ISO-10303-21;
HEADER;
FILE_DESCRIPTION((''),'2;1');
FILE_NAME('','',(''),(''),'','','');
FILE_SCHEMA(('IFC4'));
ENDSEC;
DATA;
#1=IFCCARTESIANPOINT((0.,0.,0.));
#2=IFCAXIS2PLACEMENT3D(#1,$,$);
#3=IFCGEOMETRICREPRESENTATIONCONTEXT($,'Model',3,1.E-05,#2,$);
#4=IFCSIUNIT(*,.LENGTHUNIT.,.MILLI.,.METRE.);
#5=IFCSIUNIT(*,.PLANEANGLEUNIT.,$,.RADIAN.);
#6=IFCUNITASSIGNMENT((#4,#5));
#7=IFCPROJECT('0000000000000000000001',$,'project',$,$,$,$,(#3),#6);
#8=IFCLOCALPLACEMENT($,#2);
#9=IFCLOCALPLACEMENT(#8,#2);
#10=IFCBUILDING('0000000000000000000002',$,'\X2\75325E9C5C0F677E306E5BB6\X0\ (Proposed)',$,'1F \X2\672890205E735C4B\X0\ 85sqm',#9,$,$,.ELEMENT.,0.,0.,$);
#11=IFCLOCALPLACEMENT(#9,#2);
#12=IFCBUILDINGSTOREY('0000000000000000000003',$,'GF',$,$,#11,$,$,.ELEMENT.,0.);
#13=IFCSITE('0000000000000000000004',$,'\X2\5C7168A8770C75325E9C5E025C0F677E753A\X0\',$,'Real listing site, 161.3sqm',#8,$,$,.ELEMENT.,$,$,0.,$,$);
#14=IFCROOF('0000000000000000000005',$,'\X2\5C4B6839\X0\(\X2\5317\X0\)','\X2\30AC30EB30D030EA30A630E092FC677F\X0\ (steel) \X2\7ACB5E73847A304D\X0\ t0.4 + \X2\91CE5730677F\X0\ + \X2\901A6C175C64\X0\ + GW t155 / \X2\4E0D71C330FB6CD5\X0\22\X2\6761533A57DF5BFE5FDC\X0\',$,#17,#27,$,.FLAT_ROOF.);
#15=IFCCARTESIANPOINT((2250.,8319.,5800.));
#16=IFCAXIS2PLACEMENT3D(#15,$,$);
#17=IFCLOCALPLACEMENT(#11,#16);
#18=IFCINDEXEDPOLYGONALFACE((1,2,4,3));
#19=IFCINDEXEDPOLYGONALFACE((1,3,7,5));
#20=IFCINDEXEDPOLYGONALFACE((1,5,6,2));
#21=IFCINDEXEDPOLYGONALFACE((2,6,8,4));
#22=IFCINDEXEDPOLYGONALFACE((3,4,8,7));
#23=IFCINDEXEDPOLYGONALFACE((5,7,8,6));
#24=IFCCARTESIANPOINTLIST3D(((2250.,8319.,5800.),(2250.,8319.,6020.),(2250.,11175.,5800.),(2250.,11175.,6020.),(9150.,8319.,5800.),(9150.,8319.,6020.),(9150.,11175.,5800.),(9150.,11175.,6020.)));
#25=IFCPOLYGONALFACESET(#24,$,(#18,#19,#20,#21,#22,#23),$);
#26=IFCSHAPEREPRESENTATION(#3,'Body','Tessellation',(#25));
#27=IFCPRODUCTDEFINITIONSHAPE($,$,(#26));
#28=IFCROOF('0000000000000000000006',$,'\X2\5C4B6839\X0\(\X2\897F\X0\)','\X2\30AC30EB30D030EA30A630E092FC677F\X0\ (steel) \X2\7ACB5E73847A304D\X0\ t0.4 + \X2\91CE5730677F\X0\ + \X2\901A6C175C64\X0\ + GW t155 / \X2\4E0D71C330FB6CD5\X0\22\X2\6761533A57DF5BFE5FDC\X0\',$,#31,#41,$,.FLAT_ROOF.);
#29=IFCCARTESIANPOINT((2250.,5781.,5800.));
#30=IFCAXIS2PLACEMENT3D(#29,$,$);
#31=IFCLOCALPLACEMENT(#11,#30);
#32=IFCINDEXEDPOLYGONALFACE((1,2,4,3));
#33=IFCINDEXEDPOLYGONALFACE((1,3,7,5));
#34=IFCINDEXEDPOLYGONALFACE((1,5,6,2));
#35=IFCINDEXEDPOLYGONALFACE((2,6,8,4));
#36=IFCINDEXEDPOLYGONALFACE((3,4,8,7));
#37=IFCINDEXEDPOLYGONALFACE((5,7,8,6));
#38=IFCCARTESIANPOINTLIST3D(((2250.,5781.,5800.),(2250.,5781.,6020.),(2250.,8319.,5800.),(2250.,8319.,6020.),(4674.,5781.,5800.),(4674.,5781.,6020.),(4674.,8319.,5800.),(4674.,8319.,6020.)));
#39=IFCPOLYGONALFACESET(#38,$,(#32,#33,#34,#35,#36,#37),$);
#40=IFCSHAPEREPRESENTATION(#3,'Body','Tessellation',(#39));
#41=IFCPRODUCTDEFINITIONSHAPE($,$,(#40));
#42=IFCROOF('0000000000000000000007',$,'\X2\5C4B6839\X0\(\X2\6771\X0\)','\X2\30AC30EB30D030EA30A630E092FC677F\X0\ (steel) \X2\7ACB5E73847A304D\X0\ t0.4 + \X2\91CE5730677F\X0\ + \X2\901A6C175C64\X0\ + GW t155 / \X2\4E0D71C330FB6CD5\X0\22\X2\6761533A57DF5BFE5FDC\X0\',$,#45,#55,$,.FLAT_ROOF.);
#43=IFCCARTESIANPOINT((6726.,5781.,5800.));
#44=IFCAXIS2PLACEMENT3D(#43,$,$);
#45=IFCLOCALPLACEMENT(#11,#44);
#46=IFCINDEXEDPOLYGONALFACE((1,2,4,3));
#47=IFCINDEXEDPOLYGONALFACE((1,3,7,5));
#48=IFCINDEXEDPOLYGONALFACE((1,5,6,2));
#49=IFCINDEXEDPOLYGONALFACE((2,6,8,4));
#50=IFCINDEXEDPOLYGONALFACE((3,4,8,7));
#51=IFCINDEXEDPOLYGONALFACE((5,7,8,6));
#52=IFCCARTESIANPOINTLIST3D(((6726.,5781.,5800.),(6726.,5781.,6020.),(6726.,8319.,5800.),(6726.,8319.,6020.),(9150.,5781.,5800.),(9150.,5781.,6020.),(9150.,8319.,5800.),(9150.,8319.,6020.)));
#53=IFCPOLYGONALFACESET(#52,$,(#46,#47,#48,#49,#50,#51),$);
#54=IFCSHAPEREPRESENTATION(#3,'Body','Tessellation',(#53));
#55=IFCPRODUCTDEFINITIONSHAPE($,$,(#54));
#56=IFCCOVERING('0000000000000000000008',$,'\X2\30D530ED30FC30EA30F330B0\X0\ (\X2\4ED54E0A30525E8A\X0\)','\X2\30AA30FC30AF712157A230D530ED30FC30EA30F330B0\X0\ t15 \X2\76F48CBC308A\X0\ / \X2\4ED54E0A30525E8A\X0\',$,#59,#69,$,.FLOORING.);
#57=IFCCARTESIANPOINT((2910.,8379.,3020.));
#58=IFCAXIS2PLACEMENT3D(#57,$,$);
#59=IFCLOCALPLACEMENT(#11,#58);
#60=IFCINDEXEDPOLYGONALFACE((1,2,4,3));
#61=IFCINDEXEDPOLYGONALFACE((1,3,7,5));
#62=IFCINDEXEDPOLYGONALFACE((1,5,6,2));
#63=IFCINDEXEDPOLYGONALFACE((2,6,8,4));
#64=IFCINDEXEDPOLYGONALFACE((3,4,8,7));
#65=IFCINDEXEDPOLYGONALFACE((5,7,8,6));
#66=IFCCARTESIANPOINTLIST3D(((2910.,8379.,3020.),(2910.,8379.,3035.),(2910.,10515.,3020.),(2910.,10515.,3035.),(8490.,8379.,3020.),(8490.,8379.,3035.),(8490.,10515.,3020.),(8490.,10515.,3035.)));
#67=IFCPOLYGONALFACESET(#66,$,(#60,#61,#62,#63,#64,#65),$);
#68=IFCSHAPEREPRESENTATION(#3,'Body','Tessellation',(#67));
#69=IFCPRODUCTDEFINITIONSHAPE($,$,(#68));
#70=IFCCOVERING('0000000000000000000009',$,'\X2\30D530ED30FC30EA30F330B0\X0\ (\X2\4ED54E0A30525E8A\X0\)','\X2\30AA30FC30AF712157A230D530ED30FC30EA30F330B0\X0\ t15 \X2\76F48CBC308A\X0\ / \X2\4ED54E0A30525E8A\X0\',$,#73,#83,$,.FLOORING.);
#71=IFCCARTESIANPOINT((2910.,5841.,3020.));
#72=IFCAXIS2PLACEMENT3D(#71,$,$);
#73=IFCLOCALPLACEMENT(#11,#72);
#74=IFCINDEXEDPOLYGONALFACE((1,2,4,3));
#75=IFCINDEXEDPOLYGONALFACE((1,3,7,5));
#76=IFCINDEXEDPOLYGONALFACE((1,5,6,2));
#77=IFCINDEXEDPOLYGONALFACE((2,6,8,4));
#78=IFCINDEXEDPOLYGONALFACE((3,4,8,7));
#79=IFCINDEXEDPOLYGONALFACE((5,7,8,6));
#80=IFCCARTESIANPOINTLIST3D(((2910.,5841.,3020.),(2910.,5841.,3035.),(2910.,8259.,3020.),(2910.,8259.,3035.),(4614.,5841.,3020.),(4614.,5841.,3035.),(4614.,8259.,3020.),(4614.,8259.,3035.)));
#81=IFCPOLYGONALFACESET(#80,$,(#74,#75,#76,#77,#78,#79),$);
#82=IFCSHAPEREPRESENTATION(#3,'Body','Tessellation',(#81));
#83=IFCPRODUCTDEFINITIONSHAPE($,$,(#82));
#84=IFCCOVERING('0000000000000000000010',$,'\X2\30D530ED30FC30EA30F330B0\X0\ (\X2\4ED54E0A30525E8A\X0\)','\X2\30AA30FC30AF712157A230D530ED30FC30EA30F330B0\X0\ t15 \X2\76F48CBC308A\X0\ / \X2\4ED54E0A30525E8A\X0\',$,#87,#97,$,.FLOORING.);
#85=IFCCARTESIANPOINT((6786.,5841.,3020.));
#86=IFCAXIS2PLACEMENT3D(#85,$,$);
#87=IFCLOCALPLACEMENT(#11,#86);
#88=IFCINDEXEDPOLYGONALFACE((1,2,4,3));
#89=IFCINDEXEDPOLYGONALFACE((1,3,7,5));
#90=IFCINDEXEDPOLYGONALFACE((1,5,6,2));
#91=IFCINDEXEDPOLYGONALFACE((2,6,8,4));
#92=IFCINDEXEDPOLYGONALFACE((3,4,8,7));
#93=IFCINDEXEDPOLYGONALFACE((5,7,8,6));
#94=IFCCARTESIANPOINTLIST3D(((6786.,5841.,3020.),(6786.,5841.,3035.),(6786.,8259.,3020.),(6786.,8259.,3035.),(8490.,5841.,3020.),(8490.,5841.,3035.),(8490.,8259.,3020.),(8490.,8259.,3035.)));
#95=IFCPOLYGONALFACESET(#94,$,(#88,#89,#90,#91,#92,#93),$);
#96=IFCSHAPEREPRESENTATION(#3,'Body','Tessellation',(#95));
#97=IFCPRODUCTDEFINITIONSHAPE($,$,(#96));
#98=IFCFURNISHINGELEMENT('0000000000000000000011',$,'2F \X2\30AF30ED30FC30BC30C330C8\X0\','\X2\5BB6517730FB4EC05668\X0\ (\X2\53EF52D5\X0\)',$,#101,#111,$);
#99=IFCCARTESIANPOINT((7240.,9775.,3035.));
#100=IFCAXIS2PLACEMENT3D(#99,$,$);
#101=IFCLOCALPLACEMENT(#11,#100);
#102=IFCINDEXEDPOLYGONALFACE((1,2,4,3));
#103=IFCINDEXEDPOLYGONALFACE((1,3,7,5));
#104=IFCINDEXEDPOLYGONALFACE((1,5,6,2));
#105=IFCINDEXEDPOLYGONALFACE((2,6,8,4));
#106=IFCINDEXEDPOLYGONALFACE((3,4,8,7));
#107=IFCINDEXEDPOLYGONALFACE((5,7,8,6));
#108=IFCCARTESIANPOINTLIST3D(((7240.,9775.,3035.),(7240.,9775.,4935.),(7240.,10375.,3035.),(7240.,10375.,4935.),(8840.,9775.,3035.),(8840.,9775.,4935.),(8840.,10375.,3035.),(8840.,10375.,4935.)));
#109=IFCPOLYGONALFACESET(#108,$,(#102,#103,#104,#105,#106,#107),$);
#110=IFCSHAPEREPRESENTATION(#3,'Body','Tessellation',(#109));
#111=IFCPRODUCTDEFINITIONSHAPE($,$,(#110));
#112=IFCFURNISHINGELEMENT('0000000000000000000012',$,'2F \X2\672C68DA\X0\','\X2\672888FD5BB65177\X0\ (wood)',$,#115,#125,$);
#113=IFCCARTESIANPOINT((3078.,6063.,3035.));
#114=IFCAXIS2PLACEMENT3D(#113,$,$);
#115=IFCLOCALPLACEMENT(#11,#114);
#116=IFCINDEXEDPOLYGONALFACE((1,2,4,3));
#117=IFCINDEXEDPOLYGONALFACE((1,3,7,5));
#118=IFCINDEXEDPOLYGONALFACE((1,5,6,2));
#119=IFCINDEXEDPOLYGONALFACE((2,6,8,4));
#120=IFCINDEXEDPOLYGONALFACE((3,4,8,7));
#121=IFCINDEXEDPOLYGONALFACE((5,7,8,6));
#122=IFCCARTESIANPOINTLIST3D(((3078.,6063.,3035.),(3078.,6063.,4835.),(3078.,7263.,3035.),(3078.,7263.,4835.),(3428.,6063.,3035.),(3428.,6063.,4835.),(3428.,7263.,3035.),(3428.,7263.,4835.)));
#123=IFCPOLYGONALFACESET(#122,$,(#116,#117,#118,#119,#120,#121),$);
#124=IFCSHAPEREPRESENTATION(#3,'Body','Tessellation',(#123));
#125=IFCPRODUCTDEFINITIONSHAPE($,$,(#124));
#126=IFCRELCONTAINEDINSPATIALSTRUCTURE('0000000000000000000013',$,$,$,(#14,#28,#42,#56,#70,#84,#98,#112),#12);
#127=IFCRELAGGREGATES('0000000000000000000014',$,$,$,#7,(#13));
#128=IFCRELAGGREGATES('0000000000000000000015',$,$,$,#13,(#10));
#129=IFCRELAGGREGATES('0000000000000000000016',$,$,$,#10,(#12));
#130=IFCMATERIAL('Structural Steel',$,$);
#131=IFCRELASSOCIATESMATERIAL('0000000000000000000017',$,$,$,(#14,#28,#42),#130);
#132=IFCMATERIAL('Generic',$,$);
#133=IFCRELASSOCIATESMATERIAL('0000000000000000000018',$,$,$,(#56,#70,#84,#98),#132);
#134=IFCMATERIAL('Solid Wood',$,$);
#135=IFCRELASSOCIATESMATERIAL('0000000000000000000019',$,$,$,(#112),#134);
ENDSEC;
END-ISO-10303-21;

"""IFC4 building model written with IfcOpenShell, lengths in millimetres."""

from ifc_helpers import new_model, si_unit, frame, frame_2d, origin, place, context, project, spatial, rectangle, extrude, material, element, save


model = new_model("IFC4")

# Units and contexts
model_context = context("Model", 3, precision=1e-05, world=origin())
ifc_project = project(units=[si_unit("LENGTHUNIT", "METRE", prefix="MILLI"), si_unit("PLANEANGLEUNIT", "RADIAN")], contexts=[model_context])

# Site, building, storey
site_placement = place(None, origin())
site = spatial("IfcSite", under=ifc_project, at=site_placement, Name="山梨県甲府市小松町", ObjectType="Real listing site, 161.3sqm", CompositionType="ELEMENT", RefElevation=0.0)
building_placement = place(site_placement, origin())
building = spatial("IfcBuilding", under=site, at=building_placement, Name="甲府小松の家 (Proposed)", ObjectType="1F 木造平屋 85sqm", CompositionType="ELEMENT", ElevationOfRefHeight=0.0, ElevationOfTerrain=0.0)
storey_placement = place(building_placement, origin())
storey = spatial("IfcBuildingStorey", under=building, at=storey_placement, Name="GF", CompositionType="ELEMENT", Elevation=0.0)

# Shared definitions
ifc_material_1 = material(Name="Solid Wood")

# Shared definitions
ifc_material_2 = material(Name="Generic")

# Roofs
ifc_material_3 = material(Name="Structural Steel")
for number, where, name in (
    (1, (2250.0, 8319.0, 5800.0), "屋根(北)"),
):
    element("IfcRoof", number, at=place(storey_placement, frame(where)), inside=storey, material=ifc_material_3, Name=name, Description="ガルバリウム鋼板 (steel) 立平葺き t0.4 + 野地板 + 通気層 + GW t155 / 不燃・法22条区域対応", PredefinedType="FLAT_ROOF", context=model_context, shape_type="SweptSolid", body=[
        extrude(rectangle(XDim=6900.0, YDim=2856.0, at=frame_2d((3450.0, 1428.0))), frame((2250.0, 8319.0, 5800.0)), (0.0, 0.0, 1.0), 220.0),
    ])
roof_1_placement = place(storey_placement, frame((2250.0, 5781.0, 5800.0)))
element("IfcRoof", 2, at=roof_1_placement, inside=storey, material=ifc_material_3, Name="屋根(西)", Description="ガルバリウム鋼板 (steel) 立平葺き t0.4 + 野地板 + 通気層 + GW t155 / 不燃・法22条区域対応", PredefinedType="FLAT_ROOF", context=model_context, shape_type="SweptSolid", body=[
    extrude(rectangle(XDim=2424.0, YDim=2538.0, at=frame_2d((1212.0, 1269.0))), frame((2250.0, 5781.0, 5800.0)), (0.0, 0.0, 1.0), 220.0),
])
roof_2_placement = place(storey_placement, frame((6726.0, 5781.0, 5800.0)))
element("IfcRoof", 3, at=roof_2_placement, inside=storey, material=ifc_material_3, Name="屋根(東)", Description="ガルバリウム鋼板 (steel) 立平葺き t0.4 + 野地板 + 通気層 + GW t155 / 不燃・法22条区域対応", PredefinedType="FLAT_ROOF", context=model_context, shape_type="SweptSolid", body=[
    extrude(rectangle(XDim=2424.0, YDim=2538.0, at=frame_2d((1212.0, 1269.0))), frame((6726.0, 5781.0, 5800.0)), (0.0, 0.0, 1.0), 220.0),
])

# Coverings
covering_1_placement = place(storey_placement, frame((2910.0, 8379.0, 3020.0)))
element("IfcCovering", 4, at=covering_1_placement, inside=storey, material=ifc_material_2, Name="フローリング (仕上げ床)", Description="オーク無垢フローリング t15 直貼り / 仕上げ床", PredefinedType="FLOORING", context=model_context, shape_type="SweptSolid", body=[
    extrude(rectangle(XDim=5580.0, YDim=2136.0, at=frame_2d((2790.0, 1068.0))), frame((2910.0, 8379.0, 3020.0)), (0.0, 0.0, 1.0), 15.0),
])
covering_2_placement = place(storey_placement, frame((2910.0, 5841.0, 3020.0)))
element("IfcCovering", 5, at=covering_2_placement, inside=storey, material=ifc_material_2, Name="フローリング (仕上げ床)", Description="オーク無垢フローリング t15 直貼り / 仕上げ床", PredefinedType="FLOORING", context=model_context, shape_type="SweptSolid", body=[
    extrude(rectangle(XDim=1704.0, YDim=2418.0, at=frame_2d((852.0, 1209.0))), frame((2910.0, 5841.0, 3020.0)), (0.0, 0.0, 1.0), 15.0),
])
covering_3_placement = place(storey_placement, frame((6786.0, 5841.0, 3020.0)))
element("IfcCovering", 6, at=covering_3_placement, inside=storey, material=ifc_material_2, Name="フローリング (仕上げ床)", Description="オーク無垢フローリング t15 直貼り / 仕上げ床", PredefinedType="FLOORING", context=model_context, shape_type="SweptSolid", body=[
    extrude(rectangle(XDim=1704.0, YDim=2418.0, at=frame_2d((852.0, 1209.0))), frame((6786.0, 5841.0, 3020.0)), (0.0, 0.0, 1.0), 15.0),
])

# Furnishing elements
furnishing_1_placement = place(storey_placement, frame((7240.0, 9775.0, 3035.0)))
element("IfcFurnishingElement", 7, at=furnishing_1_placement, inside=storey, material=ifc_material_2, Name="2F クローゼット", Description="家具・什器 (可動)", context=model_context, shape_type="SweptSolid", body=[
    extrude(rectangle(XDim=1600.0, YDim=600.0, at=frame_2d((800.0, 300.0))), frame((7240.0, 9775.0, 3035.0)), (0.0, 0.0, 1.0), 1900.0),
])
furnishing_2_placement = place(storey_placement, frame((3078.0, 6063.0, 3035.0)))
element("IfcFurnishingElement", 8, at=furnishing_2_placement, inside=storey, material=ifc_material_1, Name="2F 本棚", Description="木製家具 (wood)", context=model_context, shape_type="SweptSolid", body=[
    extrude(rectangle(XDim=350.0, YDim=1200.0, at=frame_2d((175.0, 600.0))), frame((3078.0, 6063.0, 3035.0)), (0.0, 0.0, 1.0), 1800.0),
])

save(model, "model.ifc")
